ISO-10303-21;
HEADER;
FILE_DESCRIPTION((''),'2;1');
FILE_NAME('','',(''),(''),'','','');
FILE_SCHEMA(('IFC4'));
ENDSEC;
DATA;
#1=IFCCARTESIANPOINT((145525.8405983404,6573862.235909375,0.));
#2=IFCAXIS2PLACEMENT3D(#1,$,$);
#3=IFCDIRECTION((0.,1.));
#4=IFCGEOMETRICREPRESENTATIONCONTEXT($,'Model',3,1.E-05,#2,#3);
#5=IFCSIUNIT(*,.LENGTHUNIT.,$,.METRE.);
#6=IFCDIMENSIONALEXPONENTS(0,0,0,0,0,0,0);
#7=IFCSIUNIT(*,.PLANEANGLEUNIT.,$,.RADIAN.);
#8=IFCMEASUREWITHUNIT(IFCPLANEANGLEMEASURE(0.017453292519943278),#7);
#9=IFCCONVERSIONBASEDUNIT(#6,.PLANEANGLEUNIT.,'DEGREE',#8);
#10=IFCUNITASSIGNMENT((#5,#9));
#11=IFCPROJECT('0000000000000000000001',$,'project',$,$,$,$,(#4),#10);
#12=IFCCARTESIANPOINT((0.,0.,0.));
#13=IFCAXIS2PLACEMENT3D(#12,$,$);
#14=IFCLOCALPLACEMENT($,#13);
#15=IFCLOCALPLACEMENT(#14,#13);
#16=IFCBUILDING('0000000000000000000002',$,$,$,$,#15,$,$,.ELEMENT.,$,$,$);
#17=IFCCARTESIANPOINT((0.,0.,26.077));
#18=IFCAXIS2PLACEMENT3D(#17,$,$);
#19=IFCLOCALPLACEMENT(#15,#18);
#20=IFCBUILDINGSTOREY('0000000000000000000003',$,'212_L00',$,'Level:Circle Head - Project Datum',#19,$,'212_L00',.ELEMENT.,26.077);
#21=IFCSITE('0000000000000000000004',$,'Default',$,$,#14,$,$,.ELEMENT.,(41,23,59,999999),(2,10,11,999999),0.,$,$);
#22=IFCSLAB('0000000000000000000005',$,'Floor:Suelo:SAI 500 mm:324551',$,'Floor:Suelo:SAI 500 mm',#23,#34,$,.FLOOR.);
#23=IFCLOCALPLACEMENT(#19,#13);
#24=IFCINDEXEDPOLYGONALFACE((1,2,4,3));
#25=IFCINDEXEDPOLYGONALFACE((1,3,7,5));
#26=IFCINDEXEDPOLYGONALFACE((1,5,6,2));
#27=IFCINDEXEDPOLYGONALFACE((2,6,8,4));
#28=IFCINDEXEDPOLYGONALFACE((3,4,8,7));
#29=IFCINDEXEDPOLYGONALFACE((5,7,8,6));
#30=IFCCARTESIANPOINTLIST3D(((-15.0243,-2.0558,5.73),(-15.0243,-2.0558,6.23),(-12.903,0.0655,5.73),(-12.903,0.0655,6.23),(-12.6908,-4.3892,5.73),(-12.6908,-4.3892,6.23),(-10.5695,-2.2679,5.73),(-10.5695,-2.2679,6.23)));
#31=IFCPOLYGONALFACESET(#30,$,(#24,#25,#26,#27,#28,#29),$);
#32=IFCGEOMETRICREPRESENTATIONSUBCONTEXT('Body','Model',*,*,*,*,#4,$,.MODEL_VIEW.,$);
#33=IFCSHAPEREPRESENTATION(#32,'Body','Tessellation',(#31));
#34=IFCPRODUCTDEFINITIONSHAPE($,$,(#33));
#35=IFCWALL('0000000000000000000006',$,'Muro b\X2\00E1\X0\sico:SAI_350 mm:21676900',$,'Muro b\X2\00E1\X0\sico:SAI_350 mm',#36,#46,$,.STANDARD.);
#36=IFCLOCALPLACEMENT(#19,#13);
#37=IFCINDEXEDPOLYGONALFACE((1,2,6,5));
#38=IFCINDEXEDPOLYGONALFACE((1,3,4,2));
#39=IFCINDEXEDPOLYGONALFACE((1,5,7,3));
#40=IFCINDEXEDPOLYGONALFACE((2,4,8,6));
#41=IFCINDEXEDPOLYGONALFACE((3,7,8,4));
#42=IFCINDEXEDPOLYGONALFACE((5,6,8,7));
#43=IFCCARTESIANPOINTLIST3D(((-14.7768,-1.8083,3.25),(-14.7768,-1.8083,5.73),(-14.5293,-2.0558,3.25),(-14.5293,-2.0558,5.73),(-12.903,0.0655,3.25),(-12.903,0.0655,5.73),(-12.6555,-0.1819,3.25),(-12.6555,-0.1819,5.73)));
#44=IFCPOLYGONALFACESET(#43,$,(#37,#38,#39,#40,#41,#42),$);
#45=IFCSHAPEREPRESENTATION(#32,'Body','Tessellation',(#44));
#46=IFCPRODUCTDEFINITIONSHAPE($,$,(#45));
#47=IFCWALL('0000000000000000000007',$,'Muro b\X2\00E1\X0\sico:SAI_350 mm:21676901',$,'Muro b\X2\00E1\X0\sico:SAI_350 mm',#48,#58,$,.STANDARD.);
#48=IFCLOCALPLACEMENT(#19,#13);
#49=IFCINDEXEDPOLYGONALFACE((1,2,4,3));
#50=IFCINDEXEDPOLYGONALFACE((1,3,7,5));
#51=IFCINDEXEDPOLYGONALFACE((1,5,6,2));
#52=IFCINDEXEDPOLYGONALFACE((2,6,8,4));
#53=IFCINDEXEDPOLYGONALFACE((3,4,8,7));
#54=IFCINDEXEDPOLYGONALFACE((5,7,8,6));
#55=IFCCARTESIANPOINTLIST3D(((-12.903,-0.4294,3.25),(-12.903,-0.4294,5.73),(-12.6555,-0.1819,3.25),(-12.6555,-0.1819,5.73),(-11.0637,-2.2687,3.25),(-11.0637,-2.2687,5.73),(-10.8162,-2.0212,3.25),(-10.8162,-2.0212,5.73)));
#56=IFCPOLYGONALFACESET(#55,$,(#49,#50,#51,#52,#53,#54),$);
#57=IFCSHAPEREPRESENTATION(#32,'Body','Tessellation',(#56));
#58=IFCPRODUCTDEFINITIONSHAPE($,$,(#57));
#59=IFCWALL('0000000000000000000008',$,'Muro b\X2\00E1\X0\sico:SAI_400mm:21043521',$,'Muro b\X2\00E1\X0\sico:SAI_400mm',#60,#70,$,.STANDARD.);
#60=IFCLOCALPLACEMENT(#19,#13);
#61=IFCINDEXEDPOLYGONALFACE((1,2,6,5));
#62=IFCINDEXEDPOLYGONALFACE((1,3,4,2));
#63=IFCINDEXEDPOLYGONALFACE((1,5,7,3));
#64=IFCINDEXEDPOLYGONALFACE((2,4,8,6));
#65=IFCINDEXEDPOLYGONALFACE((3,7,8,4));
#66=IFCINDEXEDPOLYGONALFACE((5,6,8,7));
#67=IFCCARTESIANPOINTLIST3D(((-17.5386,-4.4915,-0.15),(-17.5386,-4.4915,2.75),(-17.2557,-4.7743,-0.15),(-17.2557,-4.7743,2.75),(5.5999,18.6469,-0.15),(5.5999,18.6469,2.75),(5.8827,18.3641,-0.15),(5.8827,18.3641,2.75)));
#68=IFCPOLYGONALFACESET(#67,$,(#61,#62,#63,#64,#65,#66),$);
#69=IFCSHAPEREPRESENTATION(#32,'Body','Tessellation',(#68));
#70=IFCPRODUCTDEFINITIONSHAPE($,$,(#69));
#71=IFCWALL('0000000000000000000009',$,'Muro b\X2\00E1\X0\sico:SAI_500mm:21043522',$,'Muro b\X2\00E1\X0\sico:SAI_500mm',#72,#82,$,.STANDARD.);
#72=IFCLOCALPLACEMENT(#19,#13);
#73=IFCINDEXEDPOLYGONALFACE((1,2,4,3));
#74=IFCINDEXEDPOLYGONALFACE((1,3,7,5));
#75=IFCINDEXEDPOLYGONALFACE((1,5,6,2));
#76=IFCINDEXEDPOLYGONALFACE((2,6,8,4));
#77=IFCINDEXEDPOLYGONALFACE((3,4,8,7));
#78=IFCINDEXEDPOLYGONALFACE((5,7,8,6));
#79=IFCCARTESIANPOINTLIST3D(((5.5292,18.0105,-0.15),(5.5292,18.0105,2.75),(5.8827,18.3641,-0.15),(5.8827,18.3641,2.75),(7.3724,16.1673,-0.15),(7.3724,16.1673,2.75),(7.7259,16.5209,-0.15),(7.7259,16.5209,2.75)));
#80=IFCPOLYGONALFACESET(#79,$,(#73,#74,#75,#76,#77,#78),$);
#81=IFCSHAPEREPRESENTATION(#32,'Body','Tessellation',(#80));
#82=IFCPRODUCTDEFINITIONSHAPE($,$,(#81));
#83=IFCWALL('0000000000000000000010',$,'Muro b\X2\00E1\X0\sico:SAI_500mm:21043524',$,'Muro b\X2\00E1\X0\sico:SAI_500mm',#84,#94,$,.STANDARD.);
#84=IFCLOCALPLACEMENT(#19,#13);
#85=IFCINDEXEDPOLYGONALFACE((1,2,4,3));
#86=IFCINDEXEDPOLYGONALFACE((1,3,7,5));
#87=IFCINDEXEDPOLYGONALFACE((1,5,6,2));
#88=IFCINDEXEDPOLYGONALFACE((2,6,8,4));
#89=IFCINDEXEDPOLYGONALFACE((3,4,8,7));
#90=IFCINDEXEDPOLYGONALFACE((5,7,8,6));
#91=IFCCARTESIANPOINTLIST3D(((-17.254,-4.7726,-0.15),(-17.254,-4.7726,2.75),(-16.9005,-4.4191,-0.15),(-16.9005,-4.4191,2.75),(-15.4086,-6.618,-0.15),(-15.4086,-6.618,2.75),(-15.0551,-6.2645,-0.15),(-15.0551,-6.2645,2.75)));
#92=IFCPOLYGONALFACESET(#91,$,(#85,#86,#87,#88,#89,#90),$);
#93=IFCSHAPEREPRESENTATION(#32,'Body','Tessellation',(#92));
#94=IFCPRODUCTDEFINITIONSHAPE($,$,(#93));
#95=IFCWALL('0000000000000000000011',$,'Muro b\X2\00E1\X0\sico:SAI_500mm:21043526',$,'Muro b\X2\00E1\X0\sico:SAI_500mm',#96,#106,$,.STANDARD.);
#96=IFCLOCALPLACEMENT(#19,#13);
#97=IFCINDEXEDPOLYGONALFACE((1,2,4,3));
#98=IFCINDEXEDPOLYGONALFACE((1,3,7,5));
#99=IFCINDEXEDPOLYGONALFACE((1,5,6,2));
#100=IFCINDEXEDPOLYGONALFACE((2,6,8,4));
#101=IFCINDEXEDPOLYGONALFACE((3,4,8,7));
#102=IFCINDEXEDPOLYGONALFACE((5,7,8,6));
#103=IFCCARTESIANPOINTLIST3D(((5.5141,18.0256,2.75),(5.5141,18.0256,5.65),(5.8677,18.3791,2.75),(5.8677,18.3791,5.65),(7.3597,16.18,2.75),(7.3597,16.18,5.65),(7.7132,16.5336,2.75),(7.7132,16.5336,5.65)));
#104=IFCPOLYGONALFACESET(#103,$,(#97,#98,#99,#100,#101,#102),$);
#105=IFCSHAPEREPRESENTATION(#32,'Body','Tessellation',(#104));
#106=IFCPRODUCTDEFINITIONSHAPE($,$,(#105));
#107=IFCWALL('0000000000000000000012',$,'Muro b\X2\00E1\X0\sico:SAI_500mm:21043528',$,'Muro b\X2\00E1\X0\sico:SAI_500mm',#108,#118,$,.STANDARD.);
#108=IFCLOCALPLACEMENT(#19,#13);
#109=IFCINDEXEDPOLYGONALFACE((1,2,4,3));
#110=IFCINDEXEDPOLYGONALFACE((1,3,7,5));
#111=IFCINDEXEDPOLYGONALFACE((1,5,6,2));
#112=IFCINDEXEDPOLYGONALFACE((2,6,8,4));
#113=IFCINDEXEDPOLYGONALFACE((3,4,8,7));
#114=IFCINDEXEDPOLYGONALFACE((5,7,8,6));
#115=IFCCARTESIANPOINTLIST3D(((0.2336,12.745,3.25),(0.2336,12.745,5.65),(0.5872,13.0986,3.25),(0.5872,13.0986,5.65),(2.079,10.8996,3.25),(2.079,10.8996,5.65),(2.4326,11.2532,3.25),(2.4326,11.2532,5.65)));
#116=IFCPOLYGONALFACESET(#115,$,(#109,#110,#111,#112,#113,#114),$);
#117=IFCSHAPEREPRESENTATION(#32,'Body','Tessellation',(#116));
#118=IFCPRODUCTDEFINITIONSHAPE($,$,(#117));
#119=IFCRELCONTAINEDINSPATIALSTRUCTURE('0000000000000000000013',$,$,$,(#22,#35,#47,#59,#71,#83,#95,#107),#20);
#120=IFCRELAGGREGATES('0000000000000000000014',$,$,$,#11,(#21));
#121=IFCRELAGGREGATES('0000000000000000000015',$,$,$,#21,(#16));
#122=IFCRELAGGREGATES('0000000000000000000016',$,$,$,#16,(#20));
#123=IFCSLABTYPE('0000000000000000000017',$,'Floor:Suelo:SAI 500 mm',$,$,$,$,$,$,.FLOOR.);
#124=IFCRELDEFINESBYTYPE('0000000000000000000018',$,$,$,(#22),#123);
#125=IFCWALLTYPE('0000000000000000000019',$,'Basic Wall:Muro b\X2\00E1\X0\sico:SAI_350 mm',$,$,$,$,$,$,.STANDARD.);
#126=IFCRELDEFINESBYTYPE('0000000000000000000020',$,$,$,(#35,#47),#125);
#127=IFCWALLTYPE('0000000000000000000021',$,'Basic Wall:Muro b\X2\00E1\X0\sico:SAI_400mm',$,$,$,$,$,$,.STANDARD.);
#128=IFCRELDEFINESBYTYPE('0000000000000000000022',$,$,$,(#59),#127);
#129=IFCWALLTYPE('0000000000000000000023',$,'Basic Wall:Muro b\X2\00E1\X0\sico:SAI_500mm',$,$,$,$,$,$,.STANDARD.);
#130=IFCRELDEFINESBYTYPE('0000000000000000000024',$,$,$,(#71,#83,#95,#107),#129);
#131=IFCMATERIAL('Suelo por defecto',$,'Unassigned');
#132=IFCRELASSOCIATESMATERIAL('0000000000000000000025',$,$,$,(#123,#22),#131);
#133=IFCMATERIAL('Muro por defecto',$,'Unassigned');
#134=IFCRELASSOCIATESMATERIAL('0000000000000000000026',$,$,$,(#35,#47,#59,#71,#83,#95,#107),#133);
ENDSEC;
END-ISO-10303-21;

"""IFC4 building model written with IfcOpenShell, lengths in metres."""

from ifc_helpers import new_model, entity, si_unit, converted_unit, direction, frame, origin, place, context, subcontext, project, spatial, indexed_curve, outline, extrude, material, type_object, element, save


model = new_model("IFC4")

# Units and contexts
model_context = context("Model", 3, precision=1e-05, world=frame((145525.8405983404, 6573862.235909375, 0.0)), true_north=direction((0.0, 1.0)))
body_context = subcontext(model_context, "Body", "Model", "MODEL_VIEW")
ifc_project = project(units=[si_unit("LENGTHUNIT", "METRE"), converted_unit("PLANEANGLEUNIT", "DEGREE", entity("IfcPlaneAngleMeasure", 0.017453292519943278), si_unit("PLANEANGLEUNIT", "RADIAN"), dimensions=[0, 0, 0, 0, 0, 0, 0])], contexts=[model_context])

# Site, building, storey
site_placement = place(None, origin())
site = spatial("IfcSite", under=ifc_project, at=site_placement, Name="Default", CompositionType="ELEMENT", RefLatitude=(41, 23, 59, 999999), RefLongitude=(2, 10, 11, 999999), RefElevation=0.0)
building_placement = place(site_placement, origin())
building = spatial("IfcBuilding", under=site, at=building_placement, CompositionType="ELEMENT")
storey_placement = place(building_placement, frame((0.0, 0.0, 26.077)))
storey = spatial("IfcBuildingStorey", under=building, at=storey_placement, Name="212_L00", ObjectType="Level:Circle Head - Project Datum", LongName="212_L00", CompositionType="ELEMENT", Elevation=26.077)

# Shared definitions
ifc_material_1 = material(Name="Suelo por defecto", Category="Unassigned")
slab_type = type_object("IfcSlabType", Name="Floor:Suelo:SAI 500 mm", PredefinedType="FLOOR", material=ifc_material_1)

# Slab
slab_1_placement = place(storey_placement, origin())
element("IfcSlab", 1, at=slab_1_placement, inside=storey, type_object=slab_type, material=ifc_material_1, Name="Floor:Suelo:SAI 500 mm:324551", ObjectType="Floor:Suelo:SAI 500 mm", PredefinedType="FLOOR", context=body_context, shape_type="SweptSolid", body=[
    extrude(outline(indexed_curve([(-1.5, -1.65), (1.5, -1.65), (1.5, 1.65), (-1.5, 1.65), (-1.5, -1.65)], self_intersect=False)), frame((-12.7969, -2.1618, 6.23), z_axis=(0.0, 0.0, -1.0), x_axis=(-0.707107, -0.707107, 0.0)), (0.0, 0.0, 1.0), 0.5),
])

# Walls
ifc_material_2 = material(Name="Muro por defecto", Category="Unassigned")
wall_type_1 = type_object("IfcWallType", Name="Basic Wall:Muro básico:SAI_350 mm", PredefinedType="STANDARD")
wall_1_placement = place(storey_placement, frame((-14.6531, -1.932, 3.25), z_axis=(0.0, 0.0, 1.0), x_axis=(0.707107, 0.707107, 0.0)))
element("IfcWall", 2, at=wall_1_placement, inside=storey, type_object=wall_type_1, material=ifc_material_2, Name="Muro básico:SAI_350 mm:21676900", ObjectType="Muro básico:SAI_350 mm", PredefinedType="STANDARD", context=body_context, shape_type="SweptSolid", body=[
    extrude(outline(indexed_curve([(2.65, 0.175), (0.0, 0.175), (0.0, -0.175), (2.65, -0.175), (2.65, 0.175)], self_intersect=False)), origin(), (0.0, 0.0, 1.0), 2.48),
])
wall_2_placement = place(storey_placement, frame((-12.7792, -0.3057, 3.25), z_axis=(0.0, 0.0, 1.0), x_axis=(0.707107, -0.707107, 0.0)))
element("IfcWall", 3, at=wall_2_placement, inside=storey, type_object=wall_type_1, material=ifc_material_2, Name="Muro básico:SAI_350 mm:21676901", ObjectType="Muro básico:SAI_350 mm", PredefinedType="STANDARD", context=body_context, shape_type="SweptSolid", body=[
    extrude(outline(indexed_curve([(2.6012, 0.175), (0.0, 0.175), (0.0, -0.175), (2.6012, -0.175), (2.6012, 0.175)], self_intersect=False)), origin(), (0.0, 0.0, 1.0), 2.48),
])
wall_type_2 = type_object("IfcWallType", Name="Basic Wall:Muro básico:SAI_400mm", PredefinedType="STANDARD")
wall_3_placement = place(storey_placement, frame((5.7413, 18.5055, -0.15), z_axis=(0.0, 0.0, 1.0), x_axis=(-0.707107, -0.707107, 0.0)))
element("IfcWall", 4, at=wall_3_placement, inside=storey, type_object=wall_type_2, material=ifc_material_2, Name="Muro básico:SAI_400mm:21043521", ObjectType="Muro básico:SAI_400mm", PredefinedType="STANDARD", context=body_context, shape_type="SweptSolid", body=[
    extrude(outline(indexed_curve([(32.7227, 0.2), (0.0, 0.2), (0.0, -0.2), (32.7227, -0.2), (32.7227, 0.2)], self_intersect=False)), origin(), (0.0, 0.0, 1.0), 2.9),
])
wall_type_3 = type_object("IfcWallType", Name="Basic Wall:Muro básico:SAI_500mm", PredefinedType="STANDARD")
wall_4_placement = place(storey_placement, frame((5.7059, 18.1873, -0.15), z_axis=(0.0, 0.0, 1.0), x_axis=(0.707107, -0.707107, 0.0)))
element("IfcWall", 5, at=wall_4_placement, inside=storey, type_object=wall_type_3, material=ifc_material_2, Name="Muro básico:SAI_500mm:21043522", ObjectType="Muro básico:SAI_500mm", PredefinedType="STANDARD", context=body_context, shape_type="SweptSolid", body=[
    extrude(outline(indexed_curve([(2.6067, 0.25), (0.0, 0.25), (0.0, -0.25), (2.6067, -0.25), (2.6067, 0.25)], self_intersect=False)), origin(), (0.0, 0.0, 1.0), 2.9),
])
wall_5_placement = place(storey_placement, frame((-17.0772, -4.5959, -0.15), z_axis=(0.0, 0.0, 1.0), x_axis=(0.707107, -0.707107, 0.0)))
element("IfcWall", 6, at=wall_5_placement, inside=storey, type_object=wall_type_3, material=ifc_material_2, Name="Muro básico:SAI_500mm:21043524", ObjectType="Muro básico:SAI_500mm", PredefinedType="STANDARD", context=body_context, shape_type="SweptSolid", body=[
    extrude(outline(indexed_curve([(2.6098, 0.25), (0.0, 0.25), (0.0, -0.25), (2.6098, -0.25), (2.6098, 0.25)], self_intersect=False)), origin(), (0.0, 0.0, 1.0), 2.9),
])
wall_6_placement = place(storey_placement, frame((5.6909, 18.2023, 2.75), z_axis=(0.0, 0.0, 1.0), x_axis=(0.707107, -0.707107, 0.0)))
element("IfcWall", 7, at=wall_6_placement, inside=storey, type_object=wall_type_3, material=ifc_material_2, Name="Muro básico:SAI_500mm:21043526", ObjectType="Muro básico:SAI_500mm", PredefinedType="STANDARD", context=body_context, shape_type="SweptSolid", body=[
    extrude(outline(indexed_curve([(2.61, 0.25), (0.0, 0.25), (0.0, -0.25), (2.61, -0.25), (2.61, 0.25)], self_intersect=False)), origin(), (0.0, 0.0, 1.0), 2.9),
])
wall_7_placement = place(storey_placement, frame((0.4104, 12.9218, 3.25), z_axis=(0.0, 0.0, 1.0), x_axis=(0.707107, -0.707107, 0.0)))
element("IfcWall", 8, at=wall_7_placement, inside=storey, type_object=wall_type_3, material=ifc_material_2, Name="Muro básico:SAI_500mm:21043528", ObjectType="Muro básico:SAI_500mm", PredefinedType="STANDARD", context=body_context, shape_type="SweptSolid", body=[
    extrude(outline(indexed_curve([(2.6098, 0.25), (0.0, 0.25), (0.0, -0.25), (2.6098, -0.25), (2.6098, 0.25)], self_intersect=False)), origin(), (0.0, 0.0, 1.0), 2.4),
])

save(model, "model.ifc")
